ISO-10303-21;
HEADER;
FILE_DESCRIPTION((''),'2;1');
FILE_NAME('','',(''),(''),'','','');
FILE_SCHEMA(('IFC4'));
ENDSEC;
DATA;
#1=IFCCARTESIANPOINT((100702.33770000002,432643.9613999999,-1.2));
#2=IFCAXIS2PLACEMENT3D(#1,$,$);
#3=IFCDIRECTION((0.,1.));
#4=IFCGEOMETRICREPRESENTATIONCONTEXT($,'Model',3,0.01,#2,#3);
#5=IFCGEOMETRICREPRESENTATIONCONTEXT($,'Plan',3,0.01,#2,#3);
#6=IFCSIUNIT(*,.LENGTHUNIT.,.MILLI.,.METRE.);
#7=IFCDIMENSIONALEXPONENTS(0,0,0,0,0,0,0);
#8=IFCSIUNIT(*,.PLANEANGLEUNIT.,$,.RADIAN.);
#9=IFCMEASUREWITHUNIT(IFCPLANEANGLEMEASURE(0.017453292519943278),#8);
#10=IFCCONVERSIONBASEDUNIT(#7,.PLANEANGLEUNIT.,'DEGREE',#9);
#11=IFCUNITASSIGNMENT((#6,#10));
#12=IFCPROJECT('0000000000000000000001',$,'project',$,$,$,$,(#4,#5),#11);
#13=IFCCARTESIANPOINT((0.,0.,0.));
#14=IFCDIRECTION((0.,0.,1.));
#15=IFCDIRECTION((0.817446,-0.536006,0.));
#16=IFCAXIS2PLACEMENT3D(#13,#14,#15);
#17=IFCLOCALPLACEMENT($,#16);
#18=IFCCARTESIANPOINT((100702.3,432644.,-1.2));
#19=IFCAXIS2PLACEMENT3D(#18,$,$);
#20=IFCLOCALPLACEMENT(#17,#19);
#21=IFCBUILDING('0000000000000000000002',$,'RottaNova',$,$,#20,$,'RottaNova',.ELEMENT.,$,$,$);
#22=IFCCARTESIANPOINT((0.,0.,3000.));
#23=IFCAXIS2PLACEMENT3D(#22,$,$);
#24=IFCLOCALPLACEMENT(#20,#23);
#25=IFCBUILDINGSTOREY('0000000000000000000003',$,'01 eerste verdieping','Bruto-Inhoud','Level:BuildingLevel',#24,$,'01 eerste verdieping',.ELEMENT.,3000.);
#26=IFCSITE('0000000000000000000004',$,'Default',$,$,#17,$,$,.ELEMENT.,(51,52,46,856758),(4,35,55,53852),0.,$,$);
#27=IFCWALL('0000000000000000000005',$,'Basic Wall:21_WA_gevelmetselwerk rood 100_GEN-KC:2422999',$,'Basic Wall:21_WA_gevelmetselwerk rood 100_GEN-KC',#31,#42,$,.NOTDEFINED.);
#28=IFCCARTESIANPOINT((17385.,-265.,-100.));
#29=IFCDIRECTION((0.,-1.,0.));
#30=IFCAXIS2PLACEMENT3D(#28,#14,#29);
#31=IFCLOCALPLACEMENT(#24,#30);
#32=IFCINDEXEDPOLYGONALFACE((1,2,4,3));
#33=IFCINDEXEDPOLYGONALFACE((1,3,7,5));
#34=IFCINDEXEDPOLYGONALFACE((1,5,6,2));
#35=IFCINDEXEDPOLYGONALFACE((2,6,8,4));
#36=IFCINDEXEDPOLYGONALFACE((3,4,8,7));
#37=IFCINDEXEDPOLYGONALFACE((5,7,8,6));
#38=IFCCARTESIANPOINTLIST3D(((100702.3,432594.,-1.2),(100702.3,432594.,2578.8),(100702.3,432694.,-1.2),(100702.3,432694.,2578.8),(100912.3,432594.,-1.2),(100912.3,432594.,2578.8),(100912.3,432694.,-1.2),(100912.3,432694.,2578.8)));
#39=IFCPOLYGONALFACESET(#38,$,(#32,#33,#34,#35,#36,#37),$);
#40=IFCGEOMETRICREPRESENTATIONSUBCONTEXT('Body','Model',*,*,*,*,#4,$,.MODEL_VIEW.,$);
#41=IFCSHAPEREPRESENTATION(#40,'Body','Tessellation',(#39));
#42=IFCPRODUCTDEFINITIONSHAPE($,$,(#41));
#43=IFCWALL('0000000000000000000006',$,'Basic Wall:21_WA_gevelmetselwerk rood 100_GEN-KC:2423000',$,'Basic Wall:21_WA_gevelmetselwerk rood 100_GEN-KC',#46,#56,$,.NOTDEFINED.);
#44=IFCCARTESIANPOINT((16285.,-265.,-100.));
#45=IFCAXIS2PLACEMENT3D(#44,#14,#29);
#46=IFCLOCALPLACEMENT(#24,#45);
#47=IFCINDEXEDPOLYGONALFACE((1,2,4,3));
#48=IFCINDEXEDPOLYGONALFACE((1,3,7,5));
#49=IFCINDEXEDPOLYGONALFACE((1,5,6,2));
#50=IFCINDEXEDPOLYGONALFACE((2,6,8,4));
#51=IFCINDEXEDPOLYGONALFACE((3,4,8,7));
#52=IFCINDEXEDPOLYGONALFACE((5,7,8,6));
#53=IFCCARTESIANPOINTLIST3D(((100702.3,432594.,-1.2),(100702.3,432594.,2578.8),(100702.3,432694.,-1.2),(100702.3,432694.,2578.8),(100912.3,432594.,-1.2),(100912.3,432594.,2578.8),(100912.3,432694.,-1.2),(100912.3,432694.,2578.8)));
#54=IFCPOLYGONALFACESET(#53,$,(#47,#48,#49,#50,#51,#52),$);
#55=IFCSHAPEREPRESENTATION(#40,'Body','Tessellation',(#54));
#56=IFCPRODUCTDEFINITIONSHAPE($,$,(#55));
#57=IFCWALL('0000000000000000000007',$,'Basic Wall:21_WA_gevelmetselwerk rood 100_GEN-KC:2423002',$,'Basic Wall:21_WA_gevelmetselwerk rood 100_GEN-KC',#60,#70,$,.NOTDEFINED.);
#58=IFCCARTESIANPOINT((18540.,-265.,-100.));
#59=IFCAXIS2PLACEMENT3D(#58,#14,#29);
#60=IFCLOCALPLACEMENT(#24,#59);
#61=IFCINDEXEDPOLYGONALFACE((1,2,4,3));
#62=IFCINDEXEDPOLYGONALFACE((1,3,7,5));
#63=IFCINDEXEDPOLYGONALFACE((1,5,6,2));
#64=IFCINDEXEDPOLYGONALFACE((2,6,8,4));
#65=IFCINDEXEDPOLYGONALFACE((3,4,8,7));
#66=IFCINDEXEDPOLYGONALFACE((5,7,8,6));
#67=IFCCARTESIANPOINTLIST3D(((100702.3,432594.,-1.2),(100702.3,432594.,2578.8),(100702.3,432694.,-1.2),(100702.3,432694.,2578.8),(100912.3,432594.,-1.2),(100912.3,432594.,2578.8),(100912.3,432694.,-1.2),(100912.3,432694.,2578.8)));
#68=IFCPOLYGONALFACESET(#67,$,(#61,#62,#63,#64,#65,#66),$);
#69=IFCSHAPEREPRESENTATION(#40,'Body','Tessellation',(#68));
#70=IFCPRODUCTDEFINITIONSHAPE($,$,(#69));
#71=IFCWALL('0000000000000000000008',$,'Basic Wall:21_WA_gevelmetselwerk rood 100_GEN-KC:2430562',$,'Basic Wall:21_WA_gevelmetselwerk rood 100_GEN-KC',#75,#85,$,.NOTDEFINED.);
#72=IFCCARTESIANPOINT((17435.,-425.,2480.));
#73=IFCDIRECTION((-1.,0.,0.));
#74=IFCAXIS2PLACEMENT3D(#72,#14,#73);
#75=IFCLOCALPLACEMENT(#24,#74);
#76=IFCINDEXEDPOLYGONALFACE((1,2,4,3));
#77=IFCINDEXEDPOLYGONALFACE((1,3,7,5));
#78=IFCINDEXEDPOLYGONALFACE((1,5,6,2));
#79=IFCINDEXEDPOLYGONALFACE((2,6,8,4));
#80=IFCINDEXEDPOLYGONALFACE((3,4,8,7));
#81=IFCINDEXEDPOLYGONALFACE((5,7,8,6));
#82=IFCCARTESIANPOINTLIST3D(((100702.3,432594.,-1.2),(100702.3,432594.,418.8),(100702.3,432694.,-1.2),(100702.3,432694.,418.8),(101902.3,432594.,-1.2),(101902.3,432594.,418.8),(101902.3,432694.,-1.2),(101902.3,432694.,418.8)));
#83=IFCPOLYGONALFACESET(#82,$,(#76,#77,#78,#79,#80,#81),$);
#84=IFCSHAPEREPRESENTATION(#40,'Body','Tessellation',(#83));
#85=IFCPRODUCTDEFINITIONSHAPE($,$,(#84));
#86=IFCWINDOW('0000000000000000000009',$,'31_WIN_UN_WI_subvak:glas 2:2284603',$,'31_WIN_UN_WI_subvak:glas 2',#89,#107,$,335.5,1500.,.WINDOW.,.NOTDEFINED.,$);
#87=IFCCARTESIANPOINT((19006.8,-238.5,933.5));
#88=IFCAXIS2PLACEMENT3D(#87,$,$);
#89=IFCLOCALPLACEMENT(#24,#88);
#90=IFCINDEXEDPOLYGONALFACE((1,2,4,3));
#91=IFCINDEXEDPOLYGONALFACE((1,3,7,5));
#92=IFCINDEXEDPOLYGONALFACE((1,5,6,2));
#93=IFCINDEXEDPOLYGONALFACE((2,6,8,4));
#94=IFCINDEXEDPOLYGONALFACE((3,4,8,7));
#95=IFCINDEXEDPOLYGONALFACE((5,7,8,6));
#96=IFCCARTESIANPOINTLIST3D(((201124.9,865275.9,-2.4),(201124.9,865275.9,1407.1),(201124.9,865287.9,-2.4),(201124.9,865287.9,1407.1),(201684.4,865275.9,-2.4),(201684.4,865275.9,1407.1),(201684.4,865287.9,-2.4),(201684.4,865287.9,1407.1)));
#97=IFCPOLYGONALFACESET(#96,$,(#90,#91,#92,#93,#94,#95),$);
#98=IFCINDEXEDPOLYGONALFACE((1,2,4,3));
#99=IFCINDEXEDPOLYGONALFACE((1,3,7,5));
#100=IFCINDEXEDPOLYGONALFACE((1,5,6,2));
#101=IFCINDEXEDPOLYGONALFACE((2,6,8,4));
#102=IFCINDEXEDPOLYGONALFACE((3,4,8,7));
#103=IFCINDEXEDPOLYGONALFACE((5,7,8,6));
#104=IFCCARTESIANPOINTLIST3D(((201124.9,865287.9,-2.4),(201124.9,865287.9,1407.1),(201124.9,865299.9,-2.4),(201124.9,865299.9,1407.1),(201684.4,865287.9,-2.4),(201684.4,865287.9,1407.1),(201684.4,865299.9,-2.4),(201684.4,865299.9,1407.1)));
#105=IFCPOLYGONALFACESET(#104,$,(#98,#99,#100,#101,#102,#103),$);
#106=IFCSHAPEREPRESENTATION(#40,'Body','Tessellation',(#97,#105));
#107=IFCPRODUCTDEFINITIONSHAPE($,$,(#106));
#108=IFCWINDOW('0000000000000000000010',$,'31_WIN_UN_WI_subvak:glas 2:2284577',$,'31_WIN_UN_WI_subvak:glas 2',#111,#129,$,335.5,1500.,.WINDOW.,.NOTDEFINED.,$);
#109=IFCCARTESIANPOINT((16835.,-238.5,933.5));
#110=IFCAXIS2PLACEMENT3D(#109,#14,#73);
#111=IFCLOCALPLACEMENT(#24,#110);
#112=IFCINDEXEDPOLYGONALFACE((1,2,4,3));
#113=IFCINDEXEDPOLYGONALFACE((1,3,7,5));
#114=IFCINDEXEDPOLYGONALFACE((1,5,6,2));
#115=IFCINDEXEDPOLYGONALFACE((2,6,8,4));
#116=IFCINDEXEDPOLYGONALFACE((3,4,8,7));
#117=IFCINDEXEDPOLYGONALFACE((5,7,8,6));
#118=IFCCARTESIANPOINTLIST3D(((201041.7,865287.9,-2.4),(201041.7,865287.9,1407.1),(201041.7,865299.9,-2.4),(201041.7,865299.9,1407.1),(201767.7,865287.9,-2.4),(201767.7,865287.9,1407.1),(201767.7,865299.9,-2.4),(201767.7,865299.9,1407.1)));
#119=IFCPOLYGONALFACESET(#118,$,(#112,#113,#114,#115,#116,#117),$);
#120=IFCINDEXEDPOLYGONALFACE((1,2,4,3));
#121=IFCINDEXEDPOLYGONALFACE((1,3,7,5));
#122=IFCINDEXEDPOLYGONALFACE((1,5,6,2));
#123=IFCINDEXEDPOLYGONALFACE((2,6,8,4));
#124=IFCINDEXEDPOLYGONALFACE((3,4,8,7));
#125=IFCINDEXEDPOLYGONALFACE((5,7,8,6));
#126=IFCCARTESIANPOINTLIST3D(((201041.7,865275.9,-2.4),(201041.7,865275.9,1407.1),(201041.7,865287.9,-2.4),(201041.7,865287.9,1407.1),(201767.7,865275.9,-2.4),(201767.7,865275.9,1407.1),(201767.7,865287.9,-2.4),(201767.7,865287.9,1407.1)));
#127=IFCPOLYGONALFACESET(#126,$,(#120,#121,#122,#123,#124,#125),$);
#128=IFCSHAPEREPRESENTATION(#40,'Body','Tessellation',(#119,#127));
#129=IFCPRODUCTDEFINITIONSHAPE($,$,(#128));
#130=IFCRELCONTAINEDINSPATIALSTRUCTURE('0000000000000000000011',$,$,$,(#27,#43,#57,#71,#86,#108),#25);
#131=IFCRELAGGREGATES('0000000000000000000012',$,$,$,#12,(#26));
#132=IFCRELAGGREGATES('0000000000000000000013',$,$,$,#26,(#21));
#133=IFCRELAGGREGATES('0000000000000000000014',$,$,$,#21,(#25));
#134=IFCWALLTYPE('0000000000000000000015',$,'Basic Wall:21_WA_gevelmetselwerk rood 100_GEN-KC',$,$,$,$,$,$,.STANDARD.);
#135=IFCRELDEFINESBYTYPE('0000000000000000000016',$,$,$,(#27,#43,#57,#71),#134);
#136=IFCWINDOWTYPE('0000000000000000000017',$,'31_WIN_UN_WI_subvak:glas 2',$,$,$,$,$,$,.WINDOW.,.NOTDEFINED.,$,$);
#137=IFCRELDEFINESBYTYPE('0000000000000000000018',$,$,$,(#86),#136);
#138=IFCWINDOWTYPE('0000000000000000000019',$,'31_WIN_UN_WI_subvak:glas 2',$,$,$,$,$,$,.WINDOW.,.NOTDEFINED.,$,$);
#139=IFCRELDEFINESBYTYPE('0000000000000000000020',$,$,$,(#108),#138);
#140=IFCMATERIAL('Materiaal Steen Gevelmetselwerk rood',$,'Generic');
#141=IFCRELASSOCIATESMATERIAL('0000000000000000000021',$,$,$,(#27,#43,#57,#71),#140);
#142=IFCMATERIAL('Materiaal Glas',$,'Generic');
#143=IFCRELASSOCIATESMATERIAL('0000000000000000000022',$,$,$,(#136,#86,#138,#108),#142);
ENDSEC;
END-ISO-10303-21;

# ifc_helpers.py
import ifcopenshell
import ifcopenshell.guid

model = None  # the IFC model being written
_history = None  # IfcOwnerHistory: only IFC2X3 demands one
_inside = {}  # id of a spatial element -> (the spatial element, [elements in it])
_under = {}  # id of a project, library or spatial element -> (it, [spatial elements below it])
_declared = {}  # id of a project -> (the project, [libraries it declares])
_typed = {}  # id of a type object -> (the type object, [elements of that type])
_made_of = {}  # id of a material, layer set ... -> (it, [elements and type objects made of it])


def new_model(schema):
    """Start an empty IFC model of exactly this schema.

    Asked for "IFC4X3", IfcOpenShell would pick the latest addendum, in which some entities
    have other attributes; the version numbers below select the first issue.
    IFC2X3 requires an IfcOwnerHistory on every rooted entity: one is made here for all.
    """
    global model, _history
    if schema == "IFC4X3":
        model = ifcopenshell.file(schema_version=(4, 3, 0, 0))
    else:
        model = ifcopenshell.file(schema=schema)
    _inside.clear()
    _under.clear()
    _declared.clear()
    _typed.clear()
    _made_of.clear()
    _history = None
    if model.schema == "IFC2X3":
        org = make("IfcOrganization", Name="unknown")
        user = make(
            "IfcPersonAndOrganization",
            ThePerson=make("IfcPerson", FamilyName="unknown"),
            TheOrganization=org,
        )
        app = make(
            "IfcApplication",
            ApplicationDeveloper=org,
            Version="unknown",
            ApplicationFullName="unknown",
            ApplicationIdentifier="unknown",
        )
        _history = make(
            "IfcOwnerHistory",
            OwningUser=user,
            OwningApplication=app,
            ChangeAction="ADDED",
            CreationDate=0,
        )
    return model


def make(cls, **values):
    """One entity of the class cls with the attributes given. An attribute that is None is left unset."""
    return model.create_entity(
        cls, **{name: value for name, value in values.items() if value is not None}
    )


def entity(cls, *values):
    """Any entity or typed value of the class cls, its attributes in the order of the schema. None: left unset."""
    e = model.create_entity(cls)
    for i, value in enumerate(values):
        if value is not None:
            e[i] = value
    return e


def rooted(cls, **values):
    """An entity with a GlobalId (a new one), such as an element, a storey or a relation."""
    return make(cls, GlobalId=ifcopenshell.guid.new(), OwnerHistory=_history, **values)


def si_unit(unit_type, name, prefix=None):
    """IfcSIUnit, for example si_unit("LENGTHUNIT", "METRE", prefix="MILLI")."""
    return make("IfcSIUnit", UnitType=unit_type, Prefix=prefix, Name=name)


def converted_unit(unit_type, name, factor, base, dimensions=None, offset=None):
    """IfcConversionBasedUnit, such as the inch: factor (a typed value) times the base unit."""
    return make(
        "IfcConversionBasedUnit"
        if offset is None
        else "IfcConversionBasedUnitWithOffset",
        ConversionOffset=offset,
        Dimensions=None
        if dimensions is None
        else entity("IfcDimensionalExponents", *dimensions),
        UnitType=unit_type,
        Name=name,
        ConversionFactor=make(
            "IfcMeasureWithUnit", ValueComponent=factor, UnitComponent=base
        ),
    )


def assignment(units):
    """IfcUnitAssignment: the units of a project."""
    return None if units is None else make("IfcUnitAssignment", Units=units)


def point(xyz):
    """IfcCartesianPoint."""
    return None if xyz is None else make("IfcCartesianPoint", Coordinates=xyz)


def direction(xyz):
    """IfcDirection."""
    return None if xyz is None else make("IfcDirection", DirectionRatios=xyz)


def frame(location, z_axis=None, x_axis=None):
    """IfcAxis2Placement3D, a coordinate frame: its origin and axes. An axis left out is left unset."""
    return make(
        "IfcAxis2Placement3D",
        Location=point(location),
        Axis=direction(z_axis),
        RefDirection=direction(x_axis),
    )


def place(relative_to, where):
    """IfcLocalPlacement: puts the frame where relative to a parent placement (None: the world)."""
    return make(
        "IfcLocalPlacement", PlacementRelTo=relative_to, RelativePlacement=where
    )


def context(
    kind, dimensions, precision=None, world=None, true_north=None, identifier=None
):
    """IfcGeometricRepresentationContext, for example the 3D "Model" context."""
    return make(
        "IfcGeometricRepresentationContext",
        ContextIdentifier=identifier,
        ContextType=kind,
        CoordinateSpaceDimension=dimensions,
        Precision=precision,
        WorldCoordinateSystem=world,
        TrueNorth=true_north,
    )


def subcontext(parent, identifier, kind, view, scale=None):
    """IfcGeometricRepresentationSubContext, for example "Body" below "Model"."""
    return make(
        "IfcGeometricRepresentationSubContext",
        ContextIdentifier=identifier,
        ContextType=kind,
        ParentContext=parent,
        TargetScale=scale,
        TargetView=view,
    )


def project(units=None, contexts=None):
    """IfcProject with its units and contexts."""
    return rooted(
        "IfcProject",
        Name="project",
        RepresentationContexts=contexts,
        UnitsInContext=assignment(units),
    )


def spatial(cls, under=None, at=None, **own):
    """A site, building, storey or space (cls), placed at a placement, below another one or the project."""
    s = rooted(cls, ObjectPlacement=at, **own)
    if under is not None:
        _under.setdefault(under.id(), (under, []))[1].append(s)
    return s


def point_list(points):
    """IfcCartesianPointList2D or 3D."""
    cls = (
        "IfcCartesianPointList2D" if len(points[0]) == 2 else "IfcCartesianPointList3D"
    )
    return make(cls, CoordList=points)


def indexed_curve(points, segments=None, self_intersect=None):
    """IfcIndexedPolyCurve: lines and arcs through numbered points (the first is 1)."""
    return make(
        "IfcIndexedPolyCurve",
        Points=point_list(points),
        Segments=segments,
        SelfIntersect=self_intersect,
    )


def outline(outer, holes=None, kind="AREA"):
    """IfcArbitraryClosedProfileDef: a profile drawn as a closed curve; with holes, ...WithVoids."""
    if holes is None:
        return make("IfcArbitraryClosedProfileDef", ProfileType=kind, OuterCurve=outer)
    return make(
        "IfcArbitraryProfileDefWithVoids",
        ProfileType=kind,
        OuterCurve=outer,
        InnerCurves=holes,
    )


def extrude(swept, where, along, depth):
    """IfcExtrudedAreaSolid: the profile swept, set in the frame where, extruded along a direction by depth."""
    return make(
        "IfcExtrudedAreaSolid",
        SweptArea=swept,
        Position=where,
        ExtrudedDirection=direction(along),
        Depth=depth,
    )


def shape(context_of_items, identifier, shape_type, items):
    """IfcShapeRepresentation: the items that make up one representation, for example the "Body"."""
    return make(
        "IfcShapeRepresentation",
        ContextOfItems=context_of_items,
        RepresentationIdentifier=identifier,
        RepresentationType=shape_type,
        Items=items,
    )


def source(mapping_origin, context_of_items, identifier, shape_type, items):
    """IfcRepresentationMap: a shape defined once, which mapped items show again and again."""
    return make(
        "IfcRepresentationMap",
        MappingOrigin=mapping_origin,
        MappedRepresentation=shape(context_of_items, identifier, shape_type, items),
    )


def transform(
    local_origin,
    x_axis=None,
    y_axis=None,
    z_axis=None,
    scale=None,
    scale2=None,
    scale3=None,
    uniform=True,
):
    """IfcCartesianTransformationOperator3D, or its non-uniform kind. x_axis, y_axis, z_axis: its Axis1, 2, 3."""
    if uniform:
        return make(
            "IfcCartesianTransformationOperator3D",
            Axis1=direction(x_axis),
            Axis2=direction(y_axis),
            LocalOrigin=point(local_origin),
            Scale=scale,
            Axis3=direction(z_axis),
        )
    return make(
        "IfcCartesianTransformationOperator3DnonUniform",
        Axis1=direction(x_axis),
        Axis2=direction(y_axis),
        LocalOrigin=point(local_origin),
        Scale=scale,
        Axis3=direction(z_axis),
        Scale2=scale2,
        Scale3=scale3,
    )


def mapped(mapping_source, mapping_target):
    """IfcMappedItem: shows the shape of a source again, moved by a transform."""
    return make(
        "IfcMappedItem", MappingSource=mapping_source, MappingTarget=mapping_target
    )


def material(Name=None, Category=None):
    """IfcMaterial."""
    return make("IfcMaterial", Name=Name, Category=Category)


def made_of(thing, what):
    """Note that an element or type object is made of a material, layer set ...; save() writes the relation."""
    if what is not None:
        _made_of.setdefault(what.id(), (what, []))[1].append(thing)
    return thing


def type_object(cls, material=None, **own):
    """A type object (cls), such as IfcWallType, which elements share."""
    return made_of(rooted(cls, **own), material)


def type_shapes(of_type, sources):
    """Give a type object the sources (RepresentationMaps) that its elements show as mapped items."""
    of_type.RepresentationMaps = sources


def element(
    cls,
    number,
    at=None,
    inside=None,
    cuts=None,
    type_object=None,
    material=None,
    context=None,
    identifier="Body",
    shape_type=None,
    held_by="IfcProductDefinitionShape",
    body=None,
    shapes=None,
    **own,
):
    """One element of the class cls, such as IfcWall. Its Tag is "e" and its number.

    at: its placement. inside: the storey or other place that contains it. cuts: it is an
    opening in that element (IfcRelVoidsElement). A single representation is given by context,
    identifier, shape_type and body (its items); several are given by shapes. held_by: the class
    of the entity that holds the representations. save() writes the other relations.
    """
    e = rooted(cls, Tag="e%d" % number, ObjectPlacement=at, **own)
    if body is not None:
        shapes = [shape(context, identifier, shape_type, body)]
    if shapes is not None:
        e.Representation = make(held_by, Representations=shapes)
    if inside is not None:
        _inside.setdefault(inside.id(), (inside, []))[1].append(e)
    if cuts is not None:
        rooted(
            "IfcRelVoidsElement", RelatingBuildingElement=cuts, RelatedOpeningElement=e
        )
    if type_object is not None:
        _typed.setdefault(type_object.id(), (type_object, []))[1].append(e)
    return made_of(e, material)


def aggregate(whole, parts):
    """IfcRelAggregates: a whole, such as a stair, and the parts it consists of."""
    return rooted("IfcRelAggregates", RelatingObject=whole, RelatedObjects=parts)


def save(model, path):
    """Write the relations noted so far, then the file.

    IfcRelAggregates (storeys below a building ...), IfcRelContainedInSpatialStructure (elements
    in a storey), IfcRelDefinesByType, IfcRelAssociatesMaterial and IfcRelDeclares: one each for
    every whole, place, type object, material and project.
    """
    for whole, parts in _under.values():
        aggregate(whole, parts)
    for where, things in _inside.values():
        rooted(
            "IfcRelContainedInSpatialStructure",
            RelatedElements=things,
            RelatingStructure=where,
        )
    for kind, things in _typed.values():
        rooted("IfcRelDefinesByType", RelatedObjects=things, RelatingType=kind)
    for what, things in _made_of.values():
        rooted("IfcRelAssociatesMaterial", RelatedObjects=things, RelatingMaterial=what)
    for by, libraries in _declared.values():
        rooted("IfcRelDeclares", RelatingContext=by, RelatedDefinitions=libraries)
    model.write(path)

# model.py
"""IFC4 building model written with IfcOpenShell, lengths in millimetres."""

from ifc_helpers import new_model, entity, si_unit, converted_unit, direction, frame, place, context, subcontext, project, spatial, indexed_curve, outline, extrude, source, transform, mapped, material, type_object, type_shapes, element, save


model = new_model("IFC4")

# Units and contexts
model_context = context("Model", 3, precision=0.01, world=frame((100702.33770000002, 432643.9613999999, -1.2)), true_north=direction((0.0, 1.0)))
plan_context = context("Plan", 3, precision=0.01, world=frame((100702.33770000002, 432643.9613999999, -1.2)), true_north=direction((0.0, 1.0)))
body_context = subcontext(model_context, "Body", "Model", "MODEL_VIEW")
ifc_project = project(units=[si_unit("LENGTHUNIT", "METRE", prefix="MILLI"), converted_unit("PLANEANGLEUNIT", "DEGREE", entity("IfcPlaneAngleMeasure", 0.017453292519943278), si_unit("PLANEANGLEUNIT", "RADIAN"), dimensions=[0, 0, 0, 0, 0, 0, 0])], contexts=[model_context, plan_context])

# Site, building, storey
site_placement = place(None, frame((0.0, 0.0, 0.0), z_axis=(0.0, 0.0, 1.0), x_axis=(0.817446, -0.536006, 0.0)))
site = spatial("IfcSite", under=ifc_project, at=site_placement, Name="Default", CompositionType="ELEMENT", RefLatitude=(51, 52, 46, 856758), RefLongitude=(4, 35, 55, 53852), RefElevation=0.0)
building_placement = place(site_placement, frame((100702.3, 432644.0, -1.2)))
building = spatial("IfcBuilding", under=site, at=building_placement, Name="RottaNova", LongName="RottaNova", CompositionType="ELEMENT")
storey_placement = place(building_placement, frame((0.0, 0.0, 3000.0)))
storey = spatial("IfcBuildingStorey", under=building, at=storey_placement, Name="01 eerste verdieping", Description="Bruto-Inhoud", ObjectType="Level:BuildingLevel", LongName="01 eerste verdieping", CompositionType="ELEMENT", Elevation=3000.0)

# Shared definitions
ifc_material_1 = material(Name="Materiaal Glas", Category="Generic")

# Walls
ifc_material_2 = material(Name="Materiaal Steen Gevelmetselwerk rood", Category="Generic")
wall_type = type_object("IfcWallType", Name="Basic Wall:21_WA_gevelmetselwerk rood 100_GEN-KC", PredefinedType="STANDARD")
wall_1_placement = place(storey_placement, frame((17385.0, -265.0, -100.0), z_axis=(0.0, 0.0, 1.0), x_axis=(0.0, -1.0, 0.0)))
element("IfcWall", 1, at=wall_1_placement, inside=storey, type_object=wall_type, material=ifc_material_2, Name="Basic Wall:21_WA_gevelmetselwerk rood 100_GEN-KC:2422999", ObjectType="Basic Wall:21_WA_gevelmetselwerk rood 100_GEN-KC", PredefinedType="NOTDEFINED", context=body_context, shape_type="SweptSolid", body=[
    extrude(outline(indexed_curve([(210.0, 50.0), (0.0, 50.0), (0.0, -50.0), (210.0, -50.0), (210.0, 50.0)], self_intersect=False)), frame((100702.3, 432644.0, -1.2)), (0.0, 0.0, 1.0), 2580.0),
])
wall_2_placement = place(storey_placement, frame((16285.0, -265.0, -100.0), z_axis=(0.0, 0.0, 1.0), x_axis=(0.0, -1.0, 0.0)))
element("IfcWall", 2, at=wall_2_placement, inside=storey, type_object=wall_type, material=ifc_material_2, Name="Basic Wall:21_WA_gevelmetselwerk rood 100_GEN-KC:2423000", ObjectType="Basic Wall:21_WA_gevelmetselwerk rood 100_GEN-KC", PredefinedType="NOTDEFINED", context=body_context, shape_type="SweptSolid", body=[
    extrude(outline(indexed_curve([(210.0, 50.0), (0.0, 50.0), (0.0, -50.0), (210.0, -50.0), (210.0, 50.0)], self_intersect=False)), frame((100702.3, 432644.0, -1.2)), (0.0, 0.0, 1.0), 2580.0),
])
wall_3_placement = place(storey_placement, frame((18540.0, -265.0, -100.0), z_axis=(0.0, 0.0, 1.0), x_axis=(0.0, -1.0, 0.0)))
element("IfcWall", 3, at=wall_3_placement, inside=storey, type_object=wall_type, material=ifc_material_2, Name="Basic Wall:21_WA_gevelmetselwerk rood 100_GEN-KC:2423002", ObjectType="Basic Wall:21_WA_gevelmetselwerk rood 100_GEN-KC", PredefinedType="NOTDEFINED", context=body_context, shape_type="SweptSolid", body=[
    extrude(outline(indexed_curve([(210.0, 50.0), (0.0, 50.0), (0.0, -50.0), (210.0, -50.0), (210.0, 50.0)], self_intersect=False)), frame((100702.3, 432644.0, -1.2)), (0.0, 0.0, 1.0), 2580.0),
])
wall_4_placement = place(storey_placement, frame((17435.0, -425.0, 2480.0), z_axis=(0.0, 0.0, 1.0), x_axis=(-1.0, 0.0, 0.0)))
element("IfcWall", 4, at=wall_4_placement, inside=storey, type_object=wall_type, material=ifc_material_2, Name="Basic Wall:21_WA_gevelmetselwerk rood 100_GEN-KC:2430562", ObjectType="Basic Wall:21_WA_gevelmetselwerk rood 100_GEN-KC", PredefinedType="NOTDEFINED", context=body_context, shape_type="SweptSolid", body=[
    extrude(outline(indexed_curve([(1200.0, 50.0), (0.0, 50.0), (0.0, -50.0), (1200.0, -50.0), (1200.0, 50.0)], self_intersect=False)), frame((100702.3, 432644.0, -1.2)), (0.0, 0.0, 1.0), 420.0),
])

# Windows
window_type_1 = type_object("IfcWindowType", Name="31_WIN_UN_WI_subvak:glas 2", PartitioningType="NOTDEFINED", PredefinedType="WINDOW", material=ifc_material_1)
shared_shape_1 = source(frame((100702.3, 432644.0, -1.2)), body_context, "Body", "SweptSolid", [
    extrude(outline(indexed_curve([(-279.8, -6.0), (279.8, -6.0), (279.8, 6.0), (-279.8, 6.0), (-279.8, -6.0)], self_intersect=False)), frame((0.0, -6.0, 0.0)), (0.0, 0.0, 1.0), 1409.5),
    extrude(outline(indexed_curve([(-279.8, -6.0), (279.8, -6.0), (279.8, 6.0), (-279.8, 6.0), (-279.8, -6.0)], self_intersect=False)), frame((0.0, 6.0, 0.0)), (0.0, 0.0, 1.0), 1409.5),
])
type_shapes(window_type_1, [shared_shape_1])
window_1_placement = place(storey_placement, frame((19006.8, -238.5, 933.5)))
element("IfcWindow", 5, at=window_1_placement, inside=storey, type_object=window_type_1, material=ifc_material_1, Name="31_WIN_UN_WI_subvak:glas 2:2284603", ObjectType="31_WIN_UN_WI_subvak:glas 2", OverallHeight=335.5, OverallWidth=1500.0, PartitioningType="NOTDEFINED", PredefinedType="WINDOW", context=body_context, shape_type="MappedRepresentation", body=[
    mapped(shared_shape_1, transform((100702.3, 432644.0, -1.2), scale=1.0)),
])
window_type_2 = type_object("IfcWindowType", Name="31_WIN_UN_WI_subvak:glas 2", PartitioningType="NOTDEFINED", PredefinedType="WINDOW", material=ifc_material_1)
shared_shape_2 = source(frame((100702.3, 432644.0, -1.2)), body_context, "Body", "SweptSolid", [
    extrude(outline(indexed_curve([(-6.0, -363.0), (6.0, -363.0), (6.0, 363.0), (-6.0, 363.0), (-6.0, -363.0)], self_intersect=False)), frame((0.0, 6.0, 0.0), z_axis=(0.0, 0.0, 1.0), x_axis=(0.0, -1.0, 0.0)), (0.0, 0.0, 1.0), 1409.5),
    extrude(outline(indexed_curve([(-6.0, -363.0), (6.0, -363.0), (6.0, 363.0), (-6.0, 363.0), (-6.0, -363.0)], self_intersect=False)), frame((0.0, -6.0, 0.0), z_axis=(0.0, 0.0, 1.0), x_axis=(0.0, -1.0, 0.0)), (0.0, 0.0, 1.0), 1409.5),
])
type_shapes(window_type_2, [shared_shape_2])
window_2_placement = place(storey_placement, frame((16835.0, -238.5, 933.5), z_axis=(0.0, 0.0, 1.0), x_axis=(-1.0, 0.0, 0.0)))
element("IfcWindow", 6, at=window_2_placement, inside=storey, type_object=window_type_2, material=ifc_material_1, Name="31_WIN_UN_WI_subvak:glas 2:2284577", ObjectType="31_WIN_UN_WI_subvak:glas 2", OverallHeight=335.5, OverallWidth=1500.0, PartitioningType="NOTDEFINED", PredefinedType="WINDOW", context=body_context, shape_type="MappedRepresentation", body=[
    mapped(shared_shape_2, transform((100702.3, 432644.0, -1.2), scale=1.0)),
])

save(model, "model.ifc")
